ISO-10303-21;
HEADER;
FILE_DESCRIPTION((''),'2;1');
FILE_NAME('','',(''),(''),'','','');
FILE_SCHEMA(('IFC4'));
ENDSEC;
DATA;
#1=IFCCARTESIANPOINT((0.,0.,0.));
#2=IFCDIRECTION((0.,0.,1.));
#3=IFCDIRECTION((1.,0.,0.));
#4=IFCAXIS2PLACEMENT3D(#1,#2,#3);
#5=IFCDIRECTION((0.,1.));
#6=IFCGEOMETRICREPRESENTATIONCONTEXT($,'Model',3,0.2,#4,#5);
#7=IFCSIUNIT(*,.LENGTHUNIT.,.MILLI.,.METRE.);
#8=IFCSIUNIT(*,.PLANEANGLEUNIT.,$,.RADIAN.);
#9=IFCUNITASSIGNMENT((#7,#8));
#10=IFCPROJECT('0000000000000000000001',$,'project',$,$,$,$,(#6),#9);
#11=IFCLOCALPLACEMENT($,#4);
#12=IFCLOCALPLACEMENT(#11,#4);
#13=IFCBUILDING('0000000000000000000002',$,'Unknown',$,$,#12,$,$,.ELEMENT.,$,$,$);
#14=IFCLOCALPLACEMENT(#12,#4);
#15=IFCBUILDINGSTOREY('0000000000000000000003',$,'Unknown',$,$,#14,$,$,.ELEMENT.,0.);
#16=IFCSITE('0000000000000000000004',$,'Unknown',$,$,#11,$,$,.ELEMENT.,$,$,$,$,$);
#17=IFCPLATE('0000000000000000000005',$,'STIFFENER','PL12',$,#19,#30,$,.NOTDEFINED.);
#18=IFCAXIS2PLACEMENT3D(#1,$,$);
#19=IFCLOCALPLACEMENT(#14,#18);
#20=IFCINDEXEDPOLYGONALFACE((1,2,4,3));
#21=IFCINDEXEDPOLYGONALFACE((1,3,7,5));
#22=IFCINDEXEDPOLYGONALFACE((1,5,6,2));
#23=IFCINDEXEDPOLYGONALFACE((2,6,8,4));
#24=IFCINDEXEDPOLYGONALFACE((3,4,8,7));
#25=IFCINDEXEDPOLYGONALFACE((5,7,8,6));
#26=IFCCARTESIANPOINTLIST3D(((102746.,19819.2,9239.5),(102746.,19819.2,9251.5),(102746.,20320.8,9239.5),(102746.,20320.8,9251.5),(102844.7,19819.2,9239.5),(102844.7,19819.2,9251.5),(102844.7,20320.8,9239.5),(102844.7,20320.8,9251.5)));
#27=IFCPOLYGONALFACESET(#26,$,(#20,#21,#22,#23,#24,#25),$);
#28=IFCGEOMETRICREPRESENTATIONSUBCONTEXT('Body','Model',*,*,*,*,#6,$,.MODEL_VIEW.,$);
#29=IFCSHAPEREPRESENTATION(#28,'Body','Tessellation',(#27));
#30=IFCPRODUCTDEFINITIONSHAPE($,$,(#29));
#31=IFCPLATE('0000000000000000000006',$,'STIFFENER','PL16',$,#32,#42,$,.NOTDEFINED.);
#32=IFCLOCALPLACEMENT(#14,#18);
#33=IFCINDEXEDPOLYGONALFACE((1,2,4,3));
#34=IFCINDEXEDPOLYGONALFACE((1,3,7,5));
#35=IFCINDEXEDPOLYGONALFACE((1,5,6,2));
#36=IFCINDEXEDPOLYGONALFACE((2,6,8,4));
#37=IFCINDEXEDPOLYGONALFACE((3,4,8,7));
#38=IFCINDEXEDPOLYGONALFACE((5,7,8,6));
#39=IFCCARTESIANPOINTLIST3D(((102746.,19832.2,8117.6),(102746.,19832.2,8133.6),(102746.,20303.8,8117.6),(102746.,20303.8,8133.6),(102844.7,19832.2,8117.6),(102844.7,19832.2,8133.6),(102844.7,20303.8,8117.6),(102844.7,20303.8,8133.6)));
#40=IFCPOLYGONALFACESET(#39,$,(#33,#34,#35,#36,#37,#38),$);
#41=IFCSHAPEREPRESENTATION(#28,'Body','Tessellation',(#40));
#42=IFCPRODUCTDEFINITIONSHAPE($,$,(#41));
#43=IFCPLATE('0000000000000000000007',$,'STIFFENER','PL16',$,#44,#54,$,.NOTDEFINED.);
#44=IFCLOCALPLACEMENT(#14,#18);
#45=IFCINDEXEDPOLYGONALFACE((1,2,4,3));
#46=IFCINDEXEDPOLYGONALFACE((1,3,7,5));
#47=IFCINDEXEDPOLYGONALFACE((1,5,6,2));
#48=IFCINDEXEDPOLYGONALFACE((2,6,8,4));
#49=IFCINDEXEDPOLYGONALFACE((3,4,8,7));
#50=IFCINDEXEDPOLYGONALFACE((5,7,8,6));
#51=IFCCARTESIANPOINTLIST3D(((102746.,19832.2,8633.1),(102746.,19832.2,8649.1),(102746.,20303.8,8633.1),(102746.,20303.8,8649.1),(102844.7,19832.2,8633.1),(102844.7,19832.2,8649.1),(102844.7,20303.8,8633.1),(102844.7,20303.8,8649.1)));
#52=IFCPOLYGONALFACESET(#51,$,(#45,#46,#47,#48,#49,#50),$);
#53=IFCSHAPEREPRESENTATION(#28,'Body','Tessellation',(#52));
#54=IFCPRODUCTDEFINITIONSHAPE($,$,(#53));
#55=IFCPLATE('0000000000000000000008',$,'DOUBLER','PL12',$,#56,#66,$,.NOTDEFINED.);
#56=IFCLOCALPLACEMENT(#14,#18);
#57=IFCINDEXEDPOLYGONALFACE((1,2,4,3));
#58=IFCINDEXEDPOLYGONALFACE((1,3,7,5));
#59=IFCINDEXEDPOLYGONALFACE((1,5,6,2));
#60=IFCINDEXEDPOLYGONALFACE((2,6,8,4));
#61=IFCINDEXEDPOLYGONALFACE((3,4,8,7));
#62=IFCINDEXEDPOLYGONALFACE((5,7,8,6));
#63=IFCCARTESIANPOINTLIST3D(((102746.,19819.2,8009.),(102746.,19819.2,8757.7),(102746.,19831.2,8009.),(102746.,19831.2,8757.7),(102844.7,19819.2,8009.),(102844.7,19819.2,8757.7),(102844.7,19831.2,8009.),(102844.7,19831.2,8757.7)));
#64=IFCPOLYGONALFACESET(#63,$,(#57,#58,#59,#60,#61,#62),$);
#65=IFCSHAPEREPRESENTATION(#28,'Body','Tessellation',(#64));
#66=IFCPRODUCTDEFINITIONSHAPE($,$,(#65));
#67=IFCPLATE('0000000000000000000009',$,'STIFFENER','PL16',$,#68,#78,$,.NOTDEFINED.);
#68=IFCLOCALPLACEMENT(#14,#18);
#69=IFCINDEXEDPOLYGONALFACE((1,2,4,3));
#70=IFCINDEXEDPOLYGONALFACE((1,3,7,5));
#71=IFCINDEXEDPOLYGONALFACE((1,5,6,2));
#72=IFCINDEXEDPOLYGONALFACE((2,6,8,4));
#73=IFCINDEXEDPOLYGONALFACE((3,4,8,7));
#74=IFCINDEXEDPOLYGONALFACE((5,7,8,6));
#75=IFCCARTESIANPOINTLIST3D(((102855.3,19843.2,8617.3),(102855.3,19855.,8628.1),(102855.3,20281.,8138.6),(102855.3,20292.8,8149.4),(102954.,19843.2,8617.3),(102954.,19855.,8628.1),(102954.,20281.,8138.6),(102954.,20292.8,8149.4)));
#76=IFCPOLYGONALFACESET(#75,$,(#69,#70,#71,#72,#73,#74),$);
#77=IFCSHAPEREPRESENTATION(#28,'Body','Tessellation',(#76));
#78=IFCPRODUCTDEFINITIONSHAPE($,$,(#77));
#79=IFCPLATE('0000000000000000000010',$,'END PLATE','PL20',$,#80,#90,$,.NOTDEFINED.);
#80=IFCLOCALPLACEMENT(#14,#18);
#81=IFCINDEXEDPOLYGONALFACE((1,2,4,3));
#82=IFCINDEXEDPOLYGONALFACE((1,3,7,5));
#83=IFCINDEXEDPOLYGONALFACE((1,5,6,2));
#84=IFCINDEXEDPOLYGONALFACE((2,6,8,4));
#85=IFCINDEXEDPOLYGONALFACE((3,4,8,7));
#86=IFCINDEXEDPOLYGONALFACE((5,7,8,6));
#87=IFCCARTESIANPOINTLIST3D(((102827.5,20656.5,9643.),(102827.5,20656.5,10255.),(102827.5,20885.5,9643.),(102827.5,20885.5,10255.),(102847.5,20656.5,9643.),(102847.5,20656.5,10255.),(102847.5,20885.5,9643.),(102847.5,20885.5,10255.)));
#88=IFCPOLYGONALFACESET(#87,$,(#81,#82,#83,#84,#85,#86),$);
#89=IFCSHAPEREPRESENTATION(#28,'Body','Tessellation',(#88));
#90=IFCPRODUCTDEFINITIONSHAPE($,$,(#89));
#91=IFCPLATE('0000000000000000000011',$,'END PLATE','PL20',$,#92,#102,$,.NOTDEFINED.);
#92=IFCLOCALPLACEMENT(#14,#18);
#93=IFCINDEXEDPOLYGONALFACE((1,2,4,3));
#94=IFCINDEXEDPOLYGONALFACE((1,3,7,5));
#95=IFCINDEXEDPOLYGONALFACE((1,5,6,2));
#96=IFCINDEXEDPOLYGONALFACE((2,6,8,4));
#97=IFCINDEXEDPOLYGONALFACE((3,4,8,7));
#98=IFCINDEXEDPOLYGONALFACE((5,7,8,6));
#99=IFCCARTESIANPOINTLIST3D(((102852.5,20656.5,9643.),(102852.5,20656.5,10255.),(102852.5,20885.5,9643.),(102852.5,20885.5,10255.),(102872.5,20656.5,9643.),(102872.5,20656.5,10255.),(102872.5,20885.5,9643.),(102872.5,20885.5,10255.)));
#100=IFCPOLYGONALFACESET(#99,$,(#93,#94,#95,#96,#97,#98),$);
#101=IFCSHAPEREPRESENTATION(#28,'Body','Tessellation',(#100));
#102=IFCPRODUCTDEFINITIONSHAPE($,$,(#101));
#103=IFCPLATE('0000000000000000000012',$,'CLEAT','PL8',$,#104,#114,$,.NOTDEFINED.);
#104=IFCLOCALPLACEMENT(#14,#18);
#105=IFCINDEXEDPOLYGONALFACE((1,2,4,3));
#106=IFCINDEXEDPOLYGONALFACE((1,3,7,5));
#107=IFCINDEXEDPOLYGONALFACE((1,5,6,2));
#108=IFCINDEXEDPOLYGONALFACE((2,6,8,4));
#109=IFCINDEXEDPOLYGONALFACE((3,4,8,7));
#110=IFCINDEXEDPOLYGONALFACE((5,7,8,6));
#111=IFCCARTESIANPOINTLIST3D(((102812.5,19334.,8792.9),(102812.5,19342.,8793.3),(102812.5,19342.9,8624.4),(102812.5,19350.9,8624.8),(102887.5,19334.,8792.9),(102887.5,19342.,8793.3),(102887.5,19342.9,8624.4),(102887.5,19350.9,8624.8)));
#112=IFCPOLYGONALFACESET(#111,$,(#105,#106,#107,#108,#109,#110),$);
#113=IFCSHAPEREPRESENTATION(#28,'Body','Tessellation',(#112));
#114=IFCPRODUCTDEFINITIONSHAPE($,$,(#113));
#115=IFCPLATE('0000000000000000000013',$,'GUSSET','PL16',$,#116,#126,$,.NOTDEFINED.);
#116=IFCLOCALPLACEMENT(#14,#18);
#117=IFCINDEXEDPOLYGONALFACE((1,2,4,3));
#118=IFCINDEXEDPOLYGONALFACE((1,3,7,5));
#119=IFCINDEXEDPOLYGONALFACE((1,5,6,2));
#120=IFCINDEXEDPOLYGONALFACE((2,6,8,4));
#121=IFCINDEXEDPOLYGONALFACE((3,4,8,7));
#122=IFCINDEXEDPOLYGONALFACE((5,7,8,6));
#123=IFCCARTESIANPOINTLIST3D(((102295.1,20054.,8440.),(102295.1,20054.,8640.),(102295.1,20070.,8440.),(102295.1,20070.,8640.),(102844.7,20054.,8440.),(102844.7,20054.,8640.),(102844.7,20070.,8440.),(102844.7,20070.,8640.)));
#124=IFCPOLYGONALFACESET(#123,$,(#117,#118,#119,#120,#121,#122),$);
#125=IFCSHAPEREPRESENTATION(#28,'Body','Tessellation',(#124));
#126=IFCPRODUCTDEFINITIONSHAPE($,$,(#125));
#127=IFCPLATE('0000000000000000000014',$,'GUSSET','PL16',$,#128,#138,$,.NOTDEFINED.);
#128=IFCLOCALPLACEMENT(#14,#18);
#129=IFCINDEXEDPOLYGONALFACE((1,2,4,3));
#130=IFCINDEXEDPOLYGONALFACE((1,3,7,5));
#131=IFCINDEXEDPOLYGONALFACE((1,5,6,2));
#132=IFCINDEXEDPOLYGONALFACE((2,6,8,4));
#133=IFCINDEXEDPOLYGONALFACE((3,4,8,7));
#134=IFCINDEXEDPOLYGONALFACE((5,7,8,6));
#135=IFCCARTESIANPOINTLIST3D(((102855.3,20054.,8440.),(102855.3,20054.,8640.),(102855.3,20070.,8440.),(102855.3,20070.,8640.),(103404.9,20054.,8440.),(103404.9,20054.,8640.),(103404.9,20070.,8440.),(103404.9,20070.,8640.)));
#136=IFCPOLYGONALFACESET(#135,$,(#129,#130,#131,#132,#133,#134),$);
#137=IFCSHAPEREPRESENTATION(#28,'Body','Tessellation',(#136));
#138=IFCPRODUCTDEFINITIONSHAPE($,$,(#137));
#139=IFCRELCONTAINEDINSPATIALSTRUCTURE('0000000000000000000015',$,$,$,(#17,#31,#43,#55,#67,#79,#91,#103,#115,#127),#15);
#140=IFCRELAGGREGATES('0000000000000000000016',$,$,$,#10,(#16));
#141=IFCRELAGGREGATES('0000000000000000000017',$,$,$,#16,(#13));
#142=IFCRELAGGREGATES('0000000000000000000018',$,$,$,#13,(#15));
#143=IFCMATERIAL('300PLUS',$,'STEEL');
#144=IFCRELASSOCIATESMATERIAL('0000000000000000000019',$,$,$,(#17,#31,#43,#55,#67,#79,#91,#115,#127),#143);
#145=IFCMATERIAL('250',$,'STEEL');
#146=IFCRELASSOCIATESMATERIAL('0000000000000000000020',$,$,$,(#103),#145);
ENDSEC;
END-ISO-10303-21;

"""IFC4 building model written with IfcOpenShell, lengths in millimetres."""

from ifc_helpers import new_model, si_unit, direction, frame, origin_with_axes, place, context, subcontext, project, spatial, line, indexed_curve, outline, extrude, material, element, save


model = new_model("IFC4")

# Units and contexts
model_context = context("Model", 3, precision=0.2, world=origin_with_axes(), true_north=direction((0.0, 1.0)))
body_context = subcontext(model_context, "Body", "Model", "MODEL_VIEW")
ifc_project = project(units=[si_unit("LENGTHUNIT", "METRE", prefix="MILLI"), si_unit("PLANEANGLEUNIT", "RADIAN")], contexts=[model_context])

# Site, building, storey
site_placement = place(None, origin_with_axes())
site = spatial("IfcSite", under=ifc_project, at=site_placement, Name="Unknown", CompositionType="ELEMENT")
building_placement = place(site_placement, origin_with_axes())
building = spatial("IfcBuilding", under=site, at=building_placement, Name="Unknown", CompositionType="ELEMENT")
storey_placement = place(building_placement, origin_with_axes())
storey = spatial("IfcBuildingStorey", under=building, at=storey_placement, Name="Unknown", CompositionType="ELEMENT", Elevation=0.0)

# Shared definitions
ifc_material_1 = material(Name="300PLUS", Category="STEEL")

# Plates
ifc_material_2 = material(Name="250", Category="STEEL")
for number, where, z_axis, x_axis, name in (
    (1, (102844.7, 19819.2, 9245.5), (0.0, 0.0, 1.0), (0.0, 1.0, 0.0), "STIFFENER"),
):
    element("IfcPlate", number, at=place(storey_placement, frame(where, z_axis=z_axis, x_axis=x_axis)), inside=storey, material=ifc_material_1, Name=name, Description="PL12", PredefinedType="NOTDEFINED", context=body_context, shape_type="SolidModel", body=[
        extrude(outline(indexed_curve([(0.0, 0.0), (501.6, 0.0), (501.6, 98.7), (0.0, 98.7)], segments=[line(1, 2, 3, 4, 1)])), frame((0.0, 0.0, 6.0), z_axis=(0.0, 0.0, 1.0), x_axis=(1.0, 0.0, 0.0)), (0.0, 0.0, -1.0), 12.0),
    ])
for number, where, z_axis, x_axis, name in (
    (2, (102844.7, 19832.2, 8125.6), (0.0, 0.0, 1.0), (0.0, 1.0, 0.0), "STIFFENER"),
    (3, (102844.7, 19832.2, 8641.1), (0.0, 0.0, 1.0), (0.0, 1.0, 0.0), "STIFFENER"),
):
    element("IfcPlate", number, at=place(storey_placement, frame(where, z_axis=z_axis, x_axis=x_axis)), inside=storey, material=ifc_material_1, Name=name, Description="PL16", PredefinedType="NOTDEFINED", context=body_context, shape_type="SolidModel", body=[
        extrude(outline(indexed_curve([(0.0, 0.0), (471.6, 0.0), (471.6, 98.7), (0.0, 98.7)], segments=[line(1, 2, 3, 4, 1)])), frame((0.0, 0.0, 8.0), z_axis=(0.0, 0.0, 1.0), x_axis=(1.0, 0.0, 0.0)), (0.0, 0.0, -1.0), 16.0),
    ])
plate_1_placement = place(storey_placement, frame((102844.7, 19825.2, 8009.0), z_axis=(0.0, 1.0, 0.0), x_axis=(-1.0, 0.0, 0.0)))
element("IfcPlate", 4, at=plate_1_placement, inside=storey, material=ifc_material_1, Name="DOUBLER", Description="PL12", PredefinedType="NOTDEFINED", context=body_context, shape_type="SolidModel", body=[
    extrude(outline(indexed_curve([(0.0, 0.0), (98.7, 0.0), (98.7, 748.7), (0.0, 748.7)], segments=[line(1, 2, 3, 4, 1)])), frame((0.0, 0.0, 6.0), z_axis=(0.0, 0.0, 1.0), x_axis=(1.0, 0.0, 0.0)), (0.0, 0.0, -1.0), 12.0),
])
plate_2_placement = place(storey_placement, frame((102855.3, 20286.9, 8144.0), z_axis=(0.0, 0.737928, 0.67488), x_axis=(0.0, -0.67488, 0.737928)))
element("IfcPlate", 5, at=plate_2_placement, inside=storey, material=ifc_material_1, Name="STIFFENER", Description="PL16", PredefinedType="NOTDEFINED", context=body_context, shape_type="SolidModel", body=[
    extrude(outline(indexed_curve([(0.0, 0.0), (648.7, 0.0), (648.7, 98.7), (0.0, 98.7)], segments=[line(1, 2, 3, 4, 1)])), frame((0.0, 0.0, 8.0), z_axis=(0.0, 0.0, 1.0), x_axis=(1.0, 0.0, 0.0)), (0.0, 0.0, -1.0), 16.0),
])
for number, where, z_axis, x_axis, name in (
    (6, (102837.5, 20885.5, 9643.0), (-1.0, 0.0, 0.0), (0.0, -1.0, 0.0), "END PLATE"),
    (7, (102862.5, 20885.5, 10255.0), (1.0, 0.0, 0.0), (0.0, -1.0, 0.0), "END PLATE"),
):
    element("IfcPlate", number, at=place(storey_placement, frame(where, z_axis=z_axis, x_axis=x_axis)), inside=storey, material=ifc_material_1, Name=name, Description="PL20", PredefinedType="NOTDEFINED", context=body_context, shape_type="SolidModel", body=[
        extrude(outline(indexed_curve([(0.0, 0.0), (229.0, 0.0), (229.0, 612.0), (0.0, 612.0)], segments=[line(1, 2, 3, 4, 1)])), frame((0.0, 0.0, 10.0), z_axis=(0.0, 0.0, 1.0), x_axis=(1.0, 0.0, 0.0)), (0.0, 0.0, -1.0), 20.0),
    ])
plate_3_placement = place(storey_placement, frame((102812.5, 19338.0, 8793.1), z_axis=(0.0, 0.998608, 0.052745), x_axis=(1.0, 0.0, 0.0)))
element("IfcPlate", 8, at=plate_3_placement, inside=storey, material=ifc_material_2, Name="CLEAT", Description="PL8", PredefinedType="NOTDEFINED", context=body_context, shape_type="SolidModel", body=[
    extrude(outline(indexed_curve([(0.0, 0.0), (75.0, 0.0), (75.0, 168.7), (0.0, 168.7)], segments=[line(1, 2, 3, 4, 1)])), frame((0.0, 0.0, 4.0), z_axis=(0.0, 0.0, 1.0), x_axis=(1.0, 0.0, 0.0)), (0.0, 0.0, -1.0), 8.0),
])
for number, where, z_axis, x_axis, name in (
    (9, (102844.7, 20062.0, 8640.0), (0.0, -1.0, 0.0), (-1.0, 0.0, 0.0), "GUSSET"),
    (10, (102855.3, 20062.0, 8440.0), (0.0, -1.0, 0.0), (1.0, 0.0, 0.0), "GUSSET"),
):
    element("IfcPlate", number, at=place(storey_placement, frame(where, z_axis=z_axis, x_axis=x_axis)), inside=storey, material=ifc_material_1, Name=name, Description="PL16", PredefinedType="NOTDEFINED", context=body_context, shape_type="SolidModel", body=[
        extrude(outline(indexed_curve([(0.0, 0.0), (549.6, 0.0), (549.6, 200.0), (0.0, 200.0)], segments=[line(1, 2, 3, 4, 1)])), frame((0.0, 0.0, 8.0), z_axis=(0.0, 0.0, 1.0), x_axis=(1.0, 0.0, 0.0)), (0.0, 0.0, -1.0), 16.0),
    ])

save(model, "model.ifc")
